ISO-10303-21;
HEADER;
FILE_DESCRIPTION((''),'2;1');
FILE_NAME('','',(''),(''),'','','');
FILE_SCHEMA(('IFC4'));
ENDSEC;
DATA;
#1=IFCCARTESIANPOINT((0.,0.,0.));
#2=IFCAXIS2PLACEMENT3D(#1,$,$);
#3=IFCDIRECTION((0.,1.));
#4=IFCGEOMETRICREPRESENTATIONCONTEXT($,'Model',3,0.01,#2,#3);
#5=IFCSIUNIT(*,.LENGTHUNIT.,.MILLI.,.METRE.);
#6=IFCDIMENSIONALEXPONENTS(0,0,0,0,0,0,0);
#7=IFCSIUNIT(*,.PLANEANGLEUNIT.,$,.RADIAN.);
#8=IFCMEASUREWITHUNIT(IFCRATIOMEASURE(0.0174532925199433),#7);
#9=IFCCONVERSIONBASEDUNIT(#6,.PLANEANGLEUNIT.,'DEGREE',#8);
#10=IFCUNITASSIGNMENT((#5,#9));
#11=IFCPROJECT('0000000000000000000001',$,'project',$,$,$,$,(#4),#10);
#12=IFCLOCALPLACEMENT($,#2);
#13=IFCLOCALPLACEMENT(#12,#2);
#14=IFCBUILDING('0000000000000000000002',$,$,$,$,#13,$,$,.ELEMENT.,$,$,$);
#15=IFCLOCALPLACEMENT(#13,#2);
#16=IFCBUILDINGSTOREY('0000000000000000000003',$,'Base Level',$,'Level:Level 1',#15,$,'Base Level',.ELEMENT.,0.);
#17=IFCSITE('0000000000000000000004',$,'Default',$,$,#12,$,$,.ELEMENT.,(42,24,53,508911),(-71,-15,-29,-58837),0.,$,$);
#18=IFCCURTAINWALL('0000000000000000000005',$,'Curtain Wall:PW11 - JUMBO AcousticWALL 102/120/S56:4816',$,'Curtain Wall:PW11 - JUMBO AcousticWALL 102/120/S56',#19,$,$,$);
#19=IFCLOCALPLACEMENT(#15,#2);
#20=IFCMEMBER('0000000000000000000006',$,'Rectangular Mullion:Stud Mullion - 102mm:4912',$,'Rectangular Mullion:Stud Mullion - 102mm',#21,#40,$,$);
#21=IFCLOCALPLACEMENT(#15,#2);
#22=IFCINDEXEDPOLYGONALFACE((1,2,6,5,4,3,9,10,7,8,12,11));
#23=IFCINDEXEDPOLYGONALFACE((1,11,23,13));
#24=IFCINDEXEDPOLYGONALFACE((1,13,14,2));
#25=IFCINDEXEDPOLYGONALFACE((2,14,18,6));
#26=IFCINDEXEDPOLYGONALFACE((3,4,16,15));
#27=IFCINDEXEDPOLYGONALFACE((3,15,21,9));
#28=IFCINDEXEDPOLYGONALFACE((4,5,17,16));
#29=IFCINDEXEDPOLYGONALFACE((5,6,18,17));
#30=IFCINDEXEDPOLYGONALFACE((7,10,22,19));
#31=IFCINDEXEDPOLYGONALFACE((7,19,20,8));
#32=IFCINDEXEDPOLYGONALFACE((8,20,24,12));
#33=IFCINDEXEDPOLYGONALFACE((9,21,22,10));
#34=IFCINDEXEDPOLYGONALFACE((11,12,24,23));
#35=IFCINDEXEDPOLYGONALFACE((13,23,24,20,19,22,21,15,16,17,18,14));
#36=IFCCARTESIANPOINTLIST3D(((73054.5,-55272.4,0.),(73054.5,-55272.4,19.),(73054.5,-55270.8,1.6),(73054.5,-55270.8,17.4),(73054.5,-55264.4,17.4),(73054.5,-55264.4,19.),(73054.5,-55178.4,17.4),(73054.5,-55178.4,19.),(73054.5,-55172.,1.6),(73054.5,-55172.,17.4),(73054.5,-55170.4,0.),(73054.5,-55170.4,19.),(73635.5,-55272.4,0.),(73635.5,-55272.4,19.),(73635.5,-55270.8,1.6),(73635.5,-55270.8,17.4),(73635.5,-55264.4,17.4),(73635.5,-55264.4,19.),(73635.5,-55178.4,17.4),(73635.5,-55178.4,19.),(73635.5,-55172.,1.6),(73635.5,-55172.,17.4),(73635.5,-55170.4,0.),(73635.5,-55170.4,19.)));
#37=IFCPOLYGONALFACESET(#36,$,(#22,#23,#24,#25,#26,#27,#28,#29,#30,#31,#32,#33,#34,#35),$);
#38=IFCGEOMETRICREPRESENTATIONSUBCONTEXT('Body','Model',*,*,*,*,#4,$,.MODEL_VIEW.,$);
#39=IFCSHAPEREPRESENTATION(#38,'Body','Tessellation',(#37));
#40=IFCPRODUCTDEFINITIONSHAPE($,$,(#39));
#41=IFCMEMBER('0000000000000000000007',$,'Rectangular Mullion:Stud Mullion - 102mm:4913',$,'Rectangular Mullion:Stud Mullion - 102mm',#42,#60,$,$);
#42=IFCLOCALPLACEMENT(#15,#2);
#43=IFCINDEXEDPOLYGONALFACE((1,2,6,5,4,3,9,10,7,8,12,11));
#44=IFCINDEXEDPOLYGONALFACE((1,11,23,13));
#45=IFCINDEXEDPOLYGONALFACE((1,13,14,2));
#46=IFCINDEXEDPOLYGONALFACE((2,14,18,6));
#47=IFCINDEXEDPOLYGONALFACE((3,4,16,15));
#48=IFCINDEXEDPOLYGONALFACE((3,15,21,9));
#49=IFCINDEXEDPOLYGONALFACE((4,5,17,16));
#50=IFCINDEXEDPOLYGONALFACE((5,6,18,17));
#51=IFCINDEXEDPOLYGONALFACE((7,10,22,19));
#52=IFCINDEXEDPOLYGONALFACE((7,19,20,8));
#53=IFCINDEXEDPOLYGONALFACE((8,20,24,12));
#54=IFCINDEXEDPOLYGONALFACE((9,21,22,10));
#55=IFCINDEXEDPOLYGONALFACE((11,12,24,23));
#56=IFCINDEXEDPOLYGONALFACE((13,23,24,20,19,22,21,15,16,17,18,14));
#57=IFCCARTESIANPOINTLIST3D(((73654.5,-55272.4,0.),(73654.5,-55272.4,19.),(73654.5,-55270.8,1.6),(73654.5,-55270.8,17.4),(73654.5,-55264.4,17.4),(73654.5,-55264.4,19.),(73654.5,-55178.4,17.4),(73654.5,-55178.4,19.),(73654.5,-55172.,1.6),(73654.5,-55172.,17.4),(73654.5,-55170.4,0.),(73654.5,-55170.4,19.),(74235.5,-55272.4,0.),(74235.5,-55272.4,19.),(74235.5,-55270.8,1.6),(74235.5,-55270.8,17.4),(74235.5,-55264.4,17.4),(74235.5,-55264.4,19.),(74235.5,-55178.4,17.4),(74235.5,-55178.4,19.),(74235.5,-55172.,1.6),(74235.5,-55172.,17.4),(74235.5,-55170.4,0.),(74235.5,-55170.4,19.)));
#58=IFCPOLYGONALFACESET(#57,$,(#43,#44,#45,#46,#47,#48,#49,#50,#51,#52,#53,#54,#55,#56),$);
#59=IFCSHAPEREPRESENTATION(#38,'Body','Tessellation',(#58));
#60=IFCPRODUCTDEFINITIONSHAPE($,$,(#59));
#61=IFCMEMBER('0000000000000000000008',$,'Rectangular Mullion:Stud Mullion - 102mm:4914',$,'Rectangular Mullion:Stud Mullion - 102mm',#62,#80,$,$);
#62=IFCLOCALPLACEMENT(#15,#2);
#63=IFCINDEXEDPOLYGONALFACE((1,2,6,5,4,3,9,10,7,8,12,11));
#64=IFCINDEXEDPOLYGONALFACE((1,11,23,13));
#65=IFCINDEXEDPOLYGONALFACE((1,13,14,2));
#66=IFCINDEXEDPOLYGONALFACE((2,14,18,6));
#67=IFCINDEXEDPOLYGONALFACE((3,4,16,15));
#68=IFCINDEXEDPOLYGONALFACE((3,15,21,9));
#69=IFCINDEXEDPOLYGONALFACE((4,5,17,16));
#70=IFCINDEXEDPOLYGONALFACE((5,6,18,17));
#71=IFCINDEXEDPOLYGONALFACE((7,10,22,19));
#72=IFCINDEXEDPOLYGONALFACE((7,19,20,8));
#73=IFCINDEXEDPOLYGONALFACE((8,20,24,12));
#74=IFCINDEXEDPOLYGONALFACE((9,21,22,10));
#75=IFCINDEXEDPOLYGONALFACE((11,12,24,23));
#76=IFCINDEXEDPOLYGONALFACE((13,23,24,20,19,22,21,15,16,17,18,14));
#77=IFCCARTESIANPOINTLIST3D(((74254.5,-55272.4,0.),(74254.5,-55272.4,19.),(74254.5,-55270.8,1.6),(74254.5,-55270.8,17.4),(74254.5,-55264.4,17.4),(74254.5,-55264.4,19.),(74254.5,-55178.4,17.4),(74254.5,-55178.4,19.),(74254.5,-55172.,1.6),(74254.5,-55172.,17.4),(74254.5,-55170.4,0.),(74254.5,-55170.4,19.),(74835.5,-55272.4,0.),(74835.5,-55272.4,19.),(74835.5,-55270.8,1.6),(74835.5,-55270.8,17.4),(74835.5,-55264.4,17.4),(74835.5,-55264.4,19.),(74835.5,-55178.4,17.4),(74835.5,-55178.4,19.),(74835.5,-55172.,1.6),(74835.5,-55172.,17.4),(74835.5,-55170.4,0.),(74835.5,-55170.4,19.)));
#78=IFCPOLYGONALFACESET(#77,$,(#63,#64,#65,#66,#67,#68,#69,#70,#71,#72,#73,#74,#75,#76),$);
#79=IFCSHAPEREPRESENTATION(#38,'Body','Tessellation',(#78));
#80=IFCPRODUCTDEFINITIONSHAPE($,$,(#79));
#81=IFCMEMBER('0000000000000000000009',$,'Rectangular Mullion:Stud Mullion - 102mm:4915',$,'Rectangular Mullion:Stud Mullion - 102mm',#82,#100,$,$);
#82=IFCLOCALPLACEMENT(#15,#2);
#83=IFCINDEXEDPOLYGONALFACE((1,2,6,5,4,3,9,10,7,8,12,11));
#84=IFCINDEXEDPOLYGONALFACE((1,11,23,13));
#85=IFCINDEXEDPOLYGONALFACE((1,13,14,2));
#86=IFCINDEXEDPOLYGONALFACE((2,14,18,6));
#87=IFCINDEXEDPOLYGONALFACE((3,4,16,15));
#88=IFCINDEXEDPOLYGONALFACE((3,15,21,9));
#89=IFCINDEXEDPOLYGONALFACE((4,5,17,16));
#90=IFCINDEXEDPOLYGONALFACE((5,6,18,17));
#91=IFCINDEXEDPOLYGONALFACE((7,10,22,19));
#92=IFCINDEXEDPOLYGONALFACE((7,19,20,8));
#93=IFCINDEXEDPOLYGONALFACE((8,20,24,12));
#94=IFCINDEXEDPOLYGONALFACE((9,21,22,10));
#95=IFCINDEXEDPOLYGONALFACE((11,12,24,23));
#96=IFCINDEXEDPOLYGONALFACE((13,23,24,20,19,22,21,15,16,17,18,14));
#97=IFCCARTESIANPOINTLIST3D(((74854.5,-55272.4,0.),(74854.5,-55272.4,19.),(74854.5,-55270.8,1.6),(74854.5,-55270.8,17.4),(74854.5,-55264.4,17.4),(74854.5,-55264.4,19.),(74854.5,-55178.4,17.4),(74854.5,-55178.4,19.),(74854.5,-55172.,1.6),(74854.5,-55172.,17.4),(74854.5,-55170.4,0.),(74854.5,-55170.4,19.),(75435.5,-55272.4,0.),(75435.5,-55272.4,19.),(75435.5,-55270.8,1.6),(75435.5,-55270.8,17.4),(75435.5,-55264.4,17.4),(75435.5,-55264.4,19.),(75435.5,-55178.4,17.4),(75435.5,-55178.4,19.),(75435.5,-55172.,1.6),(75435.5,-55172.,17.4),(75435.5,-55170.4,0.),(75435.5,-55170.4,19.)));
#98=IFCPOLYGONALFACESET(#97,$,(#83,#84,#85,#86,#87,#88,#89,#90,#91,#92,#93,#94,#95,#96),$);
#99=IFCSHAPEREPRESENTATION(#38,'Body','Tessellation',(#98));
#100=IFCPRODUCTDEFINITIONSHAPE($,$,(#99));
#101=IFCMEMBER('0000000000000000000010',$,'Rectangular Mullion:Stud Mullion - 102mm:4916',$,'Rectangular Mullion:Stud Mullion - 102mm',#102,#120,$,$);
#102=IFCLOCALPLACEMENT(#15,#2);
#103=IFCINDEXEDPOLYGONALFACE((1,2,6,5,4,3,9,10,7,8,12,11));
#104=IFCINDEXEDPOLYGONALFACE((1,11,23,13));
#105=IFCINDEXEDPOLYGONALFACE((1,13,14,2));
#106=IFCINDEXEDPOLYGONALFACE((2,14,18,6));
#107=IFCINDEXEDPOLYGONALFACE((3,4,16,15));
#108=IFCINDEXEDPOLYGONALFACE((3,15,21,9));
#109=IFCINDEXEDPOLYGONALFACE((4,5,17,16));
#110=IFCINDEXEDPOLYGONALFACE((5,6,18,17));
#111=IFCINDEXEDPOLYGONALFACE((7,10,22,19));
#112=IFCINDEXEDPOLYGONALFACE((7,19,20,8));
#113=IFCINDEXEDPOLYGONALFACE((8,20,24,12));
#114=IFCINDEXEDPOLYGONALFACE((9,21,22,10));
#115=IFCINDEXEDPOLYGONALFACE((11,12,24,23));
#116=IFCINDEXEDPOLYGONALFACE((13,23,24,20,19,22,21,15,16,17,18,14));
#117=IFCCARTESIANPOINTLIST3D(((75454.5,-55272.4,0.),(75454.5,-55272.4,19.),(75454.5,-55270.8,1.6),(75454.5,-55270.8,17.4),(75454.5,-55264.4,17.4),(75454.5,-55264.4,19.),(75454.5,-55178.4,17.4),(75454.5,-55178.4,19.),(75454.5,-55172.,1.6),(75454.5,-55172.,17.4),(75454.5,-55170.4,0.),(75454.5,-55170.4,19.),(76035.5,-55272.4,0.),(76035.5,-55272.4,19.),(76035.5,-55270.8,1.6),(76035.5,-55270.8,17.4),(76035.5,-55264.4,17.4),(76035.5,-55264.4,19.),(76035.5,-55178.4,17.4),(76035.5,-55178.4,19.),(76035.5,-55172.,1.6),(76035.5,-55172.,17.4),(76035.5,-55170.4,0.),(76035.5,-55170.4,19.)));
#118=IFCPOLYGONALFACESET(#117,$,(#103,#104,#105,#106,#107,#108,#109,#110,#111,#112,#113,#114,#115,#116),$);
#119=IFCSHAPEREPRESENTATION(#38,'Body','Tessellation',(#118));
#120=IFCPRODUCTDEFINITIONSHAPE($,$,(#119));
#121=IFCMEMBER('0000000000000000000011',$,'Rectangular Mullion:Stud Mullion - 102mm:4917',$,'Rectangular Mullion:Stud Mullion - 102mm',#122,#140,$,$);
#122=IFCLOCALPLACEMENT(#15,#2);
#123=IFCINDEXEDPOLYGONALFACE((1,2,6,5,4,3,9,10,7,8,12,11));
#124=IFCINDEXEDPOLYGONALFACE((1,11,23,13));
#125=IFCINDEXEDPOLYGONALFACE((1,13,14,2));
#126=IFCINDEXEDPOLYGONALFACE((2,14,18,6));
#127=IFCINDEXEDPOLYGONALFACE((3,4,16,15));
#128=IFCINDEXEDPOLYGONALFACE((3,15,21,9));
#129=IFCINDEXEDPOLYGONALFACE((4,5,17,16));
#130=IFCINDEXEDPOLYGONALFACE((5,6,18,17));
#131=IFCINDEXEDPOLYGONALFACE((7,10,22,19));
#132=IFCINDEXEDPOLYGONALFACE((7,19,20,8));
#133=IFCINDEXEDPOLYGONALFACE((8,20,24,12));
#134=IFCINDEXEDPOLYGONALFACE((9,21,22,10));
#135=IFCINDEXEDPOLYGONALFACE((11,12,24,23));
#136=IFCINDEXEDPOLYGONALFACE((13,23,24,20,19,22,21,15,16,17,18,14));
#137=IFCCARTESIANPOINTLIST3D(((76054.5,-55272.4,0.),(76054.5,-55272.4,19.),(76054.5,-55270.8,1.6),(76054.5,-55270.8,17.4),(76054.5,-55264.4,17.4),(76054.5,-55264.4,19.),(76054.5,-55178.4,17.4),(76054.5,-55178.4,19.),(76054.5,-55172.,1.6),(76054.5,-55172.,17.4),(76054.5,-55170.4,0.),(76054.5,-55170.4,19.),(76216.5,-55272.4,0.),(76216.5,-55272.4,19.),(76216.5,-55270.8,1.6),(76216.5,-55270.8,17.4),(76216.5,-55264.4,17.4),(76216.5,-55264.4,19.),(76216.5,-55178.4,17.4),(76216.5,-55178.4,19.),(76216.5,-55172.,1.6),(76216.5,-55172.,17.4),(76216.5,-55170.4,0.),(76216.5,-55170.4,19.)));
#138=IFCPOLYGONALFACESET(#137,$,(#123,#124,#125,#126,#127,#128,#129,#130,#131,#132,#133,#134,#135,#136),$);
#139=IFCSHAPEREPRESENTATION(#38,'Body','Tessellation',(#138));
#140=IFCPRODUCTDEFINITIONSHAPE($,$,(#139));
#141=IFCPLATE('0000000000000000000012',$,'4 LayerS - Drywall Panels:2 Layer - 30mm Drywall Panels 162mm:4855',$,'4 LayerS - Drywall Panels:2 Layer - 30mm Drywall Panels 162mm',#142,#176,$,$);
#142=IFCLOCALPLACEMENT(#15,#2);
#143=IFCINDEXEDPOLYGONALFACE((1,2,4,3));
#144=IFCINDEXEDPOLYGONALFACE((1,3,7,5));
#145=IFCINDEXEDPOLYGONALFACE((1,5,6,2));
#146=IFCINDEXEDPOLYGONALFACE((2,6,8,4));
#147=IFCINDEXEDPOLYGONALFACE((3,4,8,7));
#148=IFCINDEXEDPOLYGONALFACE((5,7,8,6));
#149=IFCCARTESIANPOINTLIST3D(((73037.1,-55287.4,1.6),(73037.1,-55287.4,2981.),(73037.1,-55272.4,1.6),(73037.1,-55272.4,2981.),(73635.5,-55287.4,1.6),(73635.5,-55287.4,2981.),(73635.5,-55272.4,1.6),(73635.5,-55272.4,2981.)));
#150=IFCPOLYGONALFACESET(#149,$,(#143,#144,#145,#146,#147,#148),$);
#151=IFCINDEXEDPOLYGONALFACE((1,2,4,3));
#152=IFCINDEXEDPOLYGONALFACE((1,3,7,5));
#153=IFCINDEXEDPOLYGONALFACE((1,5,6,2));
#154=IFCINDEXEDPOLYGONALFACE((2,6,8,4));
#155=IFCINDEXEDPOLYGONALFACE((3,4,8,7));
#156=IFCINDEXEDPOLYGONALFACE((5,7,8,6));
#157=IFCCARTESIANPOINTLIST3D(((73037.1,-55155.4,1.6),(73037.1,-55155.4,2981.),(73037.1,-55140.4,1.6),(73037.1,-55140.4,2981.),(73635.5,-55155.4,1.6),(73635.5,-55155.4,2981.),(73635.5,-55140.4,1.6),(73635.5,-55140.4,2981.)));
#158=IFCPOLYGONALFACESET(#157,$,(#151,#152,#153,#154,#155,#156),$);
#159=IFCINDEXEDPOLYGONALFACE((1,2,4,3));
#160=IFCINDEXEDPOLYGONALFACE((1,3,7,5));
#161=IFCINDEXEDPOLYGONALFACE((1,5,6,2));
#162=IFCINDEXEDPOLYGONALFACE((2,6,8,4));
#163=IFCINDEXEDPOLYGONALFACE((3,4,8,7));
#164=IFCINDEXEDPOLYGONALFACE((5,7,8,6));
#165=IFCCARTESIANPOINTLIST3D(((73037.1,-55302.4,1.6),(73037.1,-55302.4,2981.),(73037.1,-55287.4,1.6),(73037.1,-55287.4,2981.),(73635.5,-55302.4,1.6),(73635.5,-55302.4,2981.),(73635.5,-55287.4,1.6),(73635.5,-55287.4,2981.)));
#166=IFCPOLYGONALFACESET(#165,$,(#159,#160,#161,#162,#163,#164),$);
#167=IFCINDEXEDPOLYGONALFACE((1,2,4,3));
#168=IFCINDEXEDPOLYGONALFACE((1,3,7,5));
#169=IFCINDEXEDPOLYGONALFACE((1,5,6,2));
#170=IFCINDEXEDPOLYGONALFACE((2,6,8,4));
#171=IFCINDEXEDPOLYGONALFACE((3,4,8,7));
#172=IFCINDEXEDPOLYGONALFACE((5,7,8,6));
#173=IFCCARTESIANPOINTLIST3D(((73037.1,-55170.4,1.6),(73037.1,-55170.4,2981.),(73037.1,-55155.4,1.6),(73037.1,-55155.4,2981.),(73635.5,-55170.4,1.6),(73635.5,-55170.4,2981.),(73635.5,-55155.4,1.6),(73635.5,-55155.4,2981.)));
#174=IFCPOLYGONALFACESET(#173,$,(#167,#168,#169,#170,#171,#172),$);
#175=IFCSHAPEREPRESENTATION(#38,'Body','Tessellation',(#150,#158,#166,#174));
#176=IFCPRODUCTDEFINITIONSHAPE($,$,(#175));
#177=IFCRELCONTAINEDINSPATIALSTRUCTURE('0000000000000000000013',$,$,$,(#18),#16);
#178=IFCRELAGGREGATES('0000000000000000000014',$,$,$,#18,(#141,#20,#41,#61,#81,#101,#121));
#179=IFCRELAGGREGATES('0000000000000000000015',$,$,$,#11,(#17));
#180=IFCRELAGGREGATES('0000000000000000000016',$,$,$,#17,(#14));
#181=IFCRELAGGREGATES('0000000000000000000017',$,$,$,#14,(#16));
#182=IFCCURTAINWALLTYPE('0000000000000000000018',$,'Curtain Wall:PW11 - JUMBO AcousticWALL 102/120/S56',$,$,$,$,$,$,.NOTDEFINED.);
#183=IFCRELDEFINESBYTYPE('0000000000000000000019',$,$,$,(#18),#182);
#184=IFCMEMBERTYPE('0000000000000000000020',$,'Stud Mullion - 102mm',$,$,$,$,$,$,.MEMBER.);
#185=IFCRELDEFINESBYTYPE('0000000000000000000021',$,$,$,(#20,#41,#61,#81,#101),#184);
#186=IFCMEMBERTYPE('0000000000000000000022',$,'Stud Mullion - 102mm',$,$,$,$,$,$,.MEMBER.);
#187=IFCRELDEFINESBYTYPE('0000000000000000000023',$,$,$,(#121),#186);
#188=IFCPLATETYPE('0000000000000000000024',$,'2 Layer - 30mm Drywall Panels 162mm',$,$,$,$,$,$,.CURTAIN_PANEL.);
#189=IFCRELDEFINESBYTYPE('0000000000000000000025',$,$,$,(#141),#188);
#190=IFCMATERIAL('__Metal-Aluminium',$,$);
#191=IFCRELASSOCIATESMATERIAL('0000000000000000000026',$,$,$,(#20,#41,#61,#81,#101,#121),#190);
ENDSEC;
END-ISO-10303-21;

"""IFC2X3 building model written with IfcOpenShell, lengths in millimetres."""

from ifc_helpers import new_model, entity, si_unit, converted_unit, direction, frame, frame_2d, origin, origin_2d_with_axis, place, context, subcontext, project, spatial, polyline, rectangle, outline, extrude, source, transform, mapped, material, type_object, type_shapes, element, aggregate, save


model = new_model("IFC2X3")

# Units and contexts
model_context = context("Model", 3, precision=0.01, world=origin(), true_north=direction((0.0, 1.0)))
body_context = subcontext(model_context, "Body", "Model", "MODEL_VIEW")
ifc_project = project(units=[si_unit("LENGTHUNIT", "METRE", prefix="MILLI"), converted_unit("PLANEANGLEUNIT", "DEGREE", entity("IfcRatioMeasure", 0.0174532925199433), si_unit("PLANEANGLEUNIT", "RADIAN"), dimensions=[0, 0, 0, 0, 0, 0, 0])], contexts=[model_context])

# Site, building, storey
site_placement = place(None, origin())
site = spatial("IfcSite", under=ifc_project, at=site_placement, Name="Default", CompositionType="ELEMENT", RefLatitude=(42, 24, 53, 508911), RefLongitude=(-71, -15, -29, -58837), RefElevation=0.0)
building_placement = place(site_placement, origin())
building = spatial("IfcBuilding", under=site, at=building_placement, CompositionType="ELEMENT")
storey_placement = place(building_placement, origin())
storey = spatial("IfcBuildingStorey", under=building, at=storey_placement, Name="Base Level", ObjectType="Level:Level 1", LongName="Base Level", CompositionType="ELEMENT", Elevation=0.0)

# Curtain wall, members, plate
curtain_wall_type = type_object("IfcCurtainWallType", Name="Curtain Wall:PW11 - JUMBO AcousticWALL 102/120/S56", PredefinedType="NOTDEFINED")
curtain_wall_placement = place(building_placement, origin())
curtain_wall = element("IfcCurtainWall", 1, at=curtain_wall_placement, inside=storey, type_object=curtain_wall_type, Name="Curtain Wall:PW11 - JUMBO AcousticWALL 102/120/S56:4816", ObjectType="Curtain Wall:PW11 - JUMBO AcousticWALL 102/120/S56")
ifc_material = material(Name="__Metal-Aluminium")
member_type_1 = type_object("IfcMemberType", Name="Stud Mullion - 102mm", PredefinedType="MEMBER")
shared_shape_1 = source(origin(), body_context, "Body", "SweptSolid", [
    extrude(outline(polyline([(43.0, -6.6), (51.0, -6.6), (51.0, 12.4), (-51.0, 12.4), (-51.0, -6.6), (-43.0, -6.6), (-43.0, -5.0), (-49.4, -5.0), (-49.4, 10.8), (49.4, 10.8), (49.4, -5.0), (43.0, -5.0), (43.0, -6.6)])), frame((-12.4, 0.0, -581.0), z_axis=(0.0, 0.0, 1.0), x_axis=(0.0, -1.0, 0.0)), (0.0, 0.0, 1.0), 581.0),
])
type_shapes(member_type_1, [shared_shape_1])
member_1_placement = place(building_placement, frame((73054.5, -55221.4, 0.0), z_axis=(-1.0, 0.0, 0.0), x_axis=(0.0, 0.0, -1.0)))
member_1 = element("IfcMember", 2, at=member_1_placement, type_object=member_type_1, material=ifc_material, Name="Rectangular Mullion:Stud Mullion - 102mm:4912", ObjectType="Rectangular Mullion:Stud Mullion - 102mm", context=body_context, shape_type="MappedRepresentation", body=[
    mapped(shared_shape_1, transform((0.0, 0.0, 0.0), scale=1.0)),
])
member_2_placement = place(building_placement, frame((73654.5, -55221.4, 0.0), z_axis=(-1.0, 0.0, 0.0), x_axis=(0.0, 0.0, -1.0)))
member_2 = element("IfcMember", 3, at=member_2_placement, type_object=member_type_1, material=ifc_material, Name="Rectangular Mullion:Stud Mullion - 102mm:4913", ObjectType="Rectangular Mullion:Stud Mullion - 102mm", context=body_context, shape_type="MappedRepresentation", body=[
    mapped(shared_shape_1, transform((0.0, 0.0, 0.0), scale=1.0)),
])
member_3_placement = place(building_placement, frame((74254.5, -55221.4, 0.0), z_axis=(-1.0, 0.0, 0.0), x_axis=(0.0, 0.0, -1.0)))
member_3 = element("IfcMember", 4, at=member_3_placement, type_object=member_type_1, material=ifc_material, Name="Rectangular Mullion:Stud Mullion - 102mm:4914", ObjectType="Rectangular Mullion:Stud Mullion - 102mm", context=body_context, shape_type="MappedRepresentation", body=[
    mapped(shared_shape_1, transform((0.0, 0.0, 0.0), scale=1.0)),
])
member_4_placement = place(building_placement, frame((74854.5, -55221.4, 0.0), z_axis=(-1.0, 0.0, 0.0), x_axis=(0.0, 0.0, -1.0)))
member_4 = element("IfcMember", 5, at=member_4_placement, type_object=member_type_1, material=ifc_material, Name="Rectangular Mullion:Stud Mullion - 102mm:4915", ObjectType="Rectangular Mullion:Stud Mullion - 102mm", context=body_context, shape_type="MappedRepresentation", body=[
    mapped(shared_shape_1, transform((0.0, 0.0, 0.0), scale=1.0)),
])
member_5_placement = place(building_placement, frame((75454.5, -55221.4, 0.0), z_axis=(-1.0, 0.0, 0.0), x_axis=(0.0, 0.0, -1.0)))
member_5 = element("IfcMember", 6, at=member_5_placement, type_object=member_type_1, material=ifc_material, Name="Rectangular Mullion:Stud Mullion - 102mm:4916", ObjectType="Rectangular Mullion:Stud Mullion - 102mm", context=body_context, shape_type="MappedRepresentation", body=[
    mapped(shared_shape_1, transform((0.0, 0.0, 0.0), scale=1.0)),
])
member_type_2 = type_object("IfcMemberType", Name="Stud Mullion - 102mm", PredefinedType="MEMBER")
shared_shape_2 = source(origin(), body_context, "Body", "SweptSolid", [
    extrude(outline(polyline([(43.0, -6.6), (51.0, -6.6), (51.0, 12.4), (-51.0, 12.4), (-51.0, -6.6), (-43.0, -6.6), (-43.0, -5.0), (-49.4, -5.0), (-49.4, 10.8), (49.4, 10.8), (49.4, -5.0), (43.0, -5.0), (43.0, -6.6)])), frame((-12.4, 0.0, -162.0), z_axis=(0.0, 0.0, 1.0), x_axis=(0.0, -1.0, 0.0)), (0.0, 0.0, 1.0), 162.0),
])
type_shapes(member_type_2, [shared_shape_2])
member_6_placement = place(building_placement, frame((76054.5, -55221.4, 0.0), z_axis=(-1.0, 0.0, 0.0), x_axis=(0.0, 0.0, -1.0)))
member_6 = element("IfcMember", 7, at=member_6_placement, type_object=member_type_2, material=ifc_material, Name="Rectangular Mullion:Stud Mullion - 102mm:4917", ObjectType="Rectangular Mullion:Stud Mullion - 102mm", context=body_context, shape_type="MappedRepresentation", body=[
    mapped(shared_shape_2, transform((0.0, 0.0, 0.0), scale=1.0)),
])
plate_type_1 = type_object("IfcPlateType", Name="2 Layer - 30mm Drywall Panels 162mm", PredefinedType="CURTAIN_PANEL")
shared_shape_3 = source(origin(), body_context, "Body", "SweptSolid", [
    extrude(rectangle(XDim=15.0, YDim=598.4, at=origin_2d_with_axis()), frame((0.0, -58.5, 0.0), z_axis=(0.0, 0.0, 1.0), x_axis=(0.0, 1.0, 0.0)), (0.0, 0.0, 1.0), 2979.4),
    extrude(rectangle(XDim=15.0, YDim=598.4, at=frame_2d((0.0, 0.0), x_axis=(1.0, 0.0))), frame((0.0, 73.5, 0.0), z_axis=(0.0, 0.0, 1.0), x_axis=(0.0, 1.0, 0.0)), (0.0, 0.0, 1.0), 2979.4),
    extrude(rectangle(XDim=598.4, YDim=15.0, at=origin_2d_with_axis()), frame((0.0, -73.5, 0.0), z_axis=(0.0, 0.0, 1.0), x_axis=(-1.0, 0.0, 0.0)), (0.0, 0.0, 1.0), 2979.4),
    extrude(rectangle(XDim=15.0, YDim=598.4, at=frame_2d((0.0, 0.0), x_axis=(1.0, 0.0))), frame((0.0, 58.5, 0.0), z_axis=(0.0, 0.0, 1.0), x_axis=(0.0, 1.0, 0.0)), (0.0, 0.0, 1.0), 2979.4),
])
type_shapes(plate_type_1, [shared_shape_3])
plate_1_placement = place(curtain_wall_placement, frame((73336.3, -55221.4, 1.6)))
plate_1 = element("IfcPlate", 8, at=plate_1_placement, type_object=plate_type_1, Name="4 LayerS - Drywall Panels:2 Layer - 30mm Drywall Panels 162mm:4855", ObjectType="4 LayerS - Drywall Panels:2 Layer - 30mm Drywall Panels 162mm", context=body_context, shape_type="MappedRepresentation", body=[
    mapped(shared_shape_3, transform((0.0, 0.0, 0.0), scale=1.0)),
])
aggregate(curtain_wall, [plate_1, member_1, member_2, member_3, member_4, member_5, member_6])

save(model, "model.ifc")
